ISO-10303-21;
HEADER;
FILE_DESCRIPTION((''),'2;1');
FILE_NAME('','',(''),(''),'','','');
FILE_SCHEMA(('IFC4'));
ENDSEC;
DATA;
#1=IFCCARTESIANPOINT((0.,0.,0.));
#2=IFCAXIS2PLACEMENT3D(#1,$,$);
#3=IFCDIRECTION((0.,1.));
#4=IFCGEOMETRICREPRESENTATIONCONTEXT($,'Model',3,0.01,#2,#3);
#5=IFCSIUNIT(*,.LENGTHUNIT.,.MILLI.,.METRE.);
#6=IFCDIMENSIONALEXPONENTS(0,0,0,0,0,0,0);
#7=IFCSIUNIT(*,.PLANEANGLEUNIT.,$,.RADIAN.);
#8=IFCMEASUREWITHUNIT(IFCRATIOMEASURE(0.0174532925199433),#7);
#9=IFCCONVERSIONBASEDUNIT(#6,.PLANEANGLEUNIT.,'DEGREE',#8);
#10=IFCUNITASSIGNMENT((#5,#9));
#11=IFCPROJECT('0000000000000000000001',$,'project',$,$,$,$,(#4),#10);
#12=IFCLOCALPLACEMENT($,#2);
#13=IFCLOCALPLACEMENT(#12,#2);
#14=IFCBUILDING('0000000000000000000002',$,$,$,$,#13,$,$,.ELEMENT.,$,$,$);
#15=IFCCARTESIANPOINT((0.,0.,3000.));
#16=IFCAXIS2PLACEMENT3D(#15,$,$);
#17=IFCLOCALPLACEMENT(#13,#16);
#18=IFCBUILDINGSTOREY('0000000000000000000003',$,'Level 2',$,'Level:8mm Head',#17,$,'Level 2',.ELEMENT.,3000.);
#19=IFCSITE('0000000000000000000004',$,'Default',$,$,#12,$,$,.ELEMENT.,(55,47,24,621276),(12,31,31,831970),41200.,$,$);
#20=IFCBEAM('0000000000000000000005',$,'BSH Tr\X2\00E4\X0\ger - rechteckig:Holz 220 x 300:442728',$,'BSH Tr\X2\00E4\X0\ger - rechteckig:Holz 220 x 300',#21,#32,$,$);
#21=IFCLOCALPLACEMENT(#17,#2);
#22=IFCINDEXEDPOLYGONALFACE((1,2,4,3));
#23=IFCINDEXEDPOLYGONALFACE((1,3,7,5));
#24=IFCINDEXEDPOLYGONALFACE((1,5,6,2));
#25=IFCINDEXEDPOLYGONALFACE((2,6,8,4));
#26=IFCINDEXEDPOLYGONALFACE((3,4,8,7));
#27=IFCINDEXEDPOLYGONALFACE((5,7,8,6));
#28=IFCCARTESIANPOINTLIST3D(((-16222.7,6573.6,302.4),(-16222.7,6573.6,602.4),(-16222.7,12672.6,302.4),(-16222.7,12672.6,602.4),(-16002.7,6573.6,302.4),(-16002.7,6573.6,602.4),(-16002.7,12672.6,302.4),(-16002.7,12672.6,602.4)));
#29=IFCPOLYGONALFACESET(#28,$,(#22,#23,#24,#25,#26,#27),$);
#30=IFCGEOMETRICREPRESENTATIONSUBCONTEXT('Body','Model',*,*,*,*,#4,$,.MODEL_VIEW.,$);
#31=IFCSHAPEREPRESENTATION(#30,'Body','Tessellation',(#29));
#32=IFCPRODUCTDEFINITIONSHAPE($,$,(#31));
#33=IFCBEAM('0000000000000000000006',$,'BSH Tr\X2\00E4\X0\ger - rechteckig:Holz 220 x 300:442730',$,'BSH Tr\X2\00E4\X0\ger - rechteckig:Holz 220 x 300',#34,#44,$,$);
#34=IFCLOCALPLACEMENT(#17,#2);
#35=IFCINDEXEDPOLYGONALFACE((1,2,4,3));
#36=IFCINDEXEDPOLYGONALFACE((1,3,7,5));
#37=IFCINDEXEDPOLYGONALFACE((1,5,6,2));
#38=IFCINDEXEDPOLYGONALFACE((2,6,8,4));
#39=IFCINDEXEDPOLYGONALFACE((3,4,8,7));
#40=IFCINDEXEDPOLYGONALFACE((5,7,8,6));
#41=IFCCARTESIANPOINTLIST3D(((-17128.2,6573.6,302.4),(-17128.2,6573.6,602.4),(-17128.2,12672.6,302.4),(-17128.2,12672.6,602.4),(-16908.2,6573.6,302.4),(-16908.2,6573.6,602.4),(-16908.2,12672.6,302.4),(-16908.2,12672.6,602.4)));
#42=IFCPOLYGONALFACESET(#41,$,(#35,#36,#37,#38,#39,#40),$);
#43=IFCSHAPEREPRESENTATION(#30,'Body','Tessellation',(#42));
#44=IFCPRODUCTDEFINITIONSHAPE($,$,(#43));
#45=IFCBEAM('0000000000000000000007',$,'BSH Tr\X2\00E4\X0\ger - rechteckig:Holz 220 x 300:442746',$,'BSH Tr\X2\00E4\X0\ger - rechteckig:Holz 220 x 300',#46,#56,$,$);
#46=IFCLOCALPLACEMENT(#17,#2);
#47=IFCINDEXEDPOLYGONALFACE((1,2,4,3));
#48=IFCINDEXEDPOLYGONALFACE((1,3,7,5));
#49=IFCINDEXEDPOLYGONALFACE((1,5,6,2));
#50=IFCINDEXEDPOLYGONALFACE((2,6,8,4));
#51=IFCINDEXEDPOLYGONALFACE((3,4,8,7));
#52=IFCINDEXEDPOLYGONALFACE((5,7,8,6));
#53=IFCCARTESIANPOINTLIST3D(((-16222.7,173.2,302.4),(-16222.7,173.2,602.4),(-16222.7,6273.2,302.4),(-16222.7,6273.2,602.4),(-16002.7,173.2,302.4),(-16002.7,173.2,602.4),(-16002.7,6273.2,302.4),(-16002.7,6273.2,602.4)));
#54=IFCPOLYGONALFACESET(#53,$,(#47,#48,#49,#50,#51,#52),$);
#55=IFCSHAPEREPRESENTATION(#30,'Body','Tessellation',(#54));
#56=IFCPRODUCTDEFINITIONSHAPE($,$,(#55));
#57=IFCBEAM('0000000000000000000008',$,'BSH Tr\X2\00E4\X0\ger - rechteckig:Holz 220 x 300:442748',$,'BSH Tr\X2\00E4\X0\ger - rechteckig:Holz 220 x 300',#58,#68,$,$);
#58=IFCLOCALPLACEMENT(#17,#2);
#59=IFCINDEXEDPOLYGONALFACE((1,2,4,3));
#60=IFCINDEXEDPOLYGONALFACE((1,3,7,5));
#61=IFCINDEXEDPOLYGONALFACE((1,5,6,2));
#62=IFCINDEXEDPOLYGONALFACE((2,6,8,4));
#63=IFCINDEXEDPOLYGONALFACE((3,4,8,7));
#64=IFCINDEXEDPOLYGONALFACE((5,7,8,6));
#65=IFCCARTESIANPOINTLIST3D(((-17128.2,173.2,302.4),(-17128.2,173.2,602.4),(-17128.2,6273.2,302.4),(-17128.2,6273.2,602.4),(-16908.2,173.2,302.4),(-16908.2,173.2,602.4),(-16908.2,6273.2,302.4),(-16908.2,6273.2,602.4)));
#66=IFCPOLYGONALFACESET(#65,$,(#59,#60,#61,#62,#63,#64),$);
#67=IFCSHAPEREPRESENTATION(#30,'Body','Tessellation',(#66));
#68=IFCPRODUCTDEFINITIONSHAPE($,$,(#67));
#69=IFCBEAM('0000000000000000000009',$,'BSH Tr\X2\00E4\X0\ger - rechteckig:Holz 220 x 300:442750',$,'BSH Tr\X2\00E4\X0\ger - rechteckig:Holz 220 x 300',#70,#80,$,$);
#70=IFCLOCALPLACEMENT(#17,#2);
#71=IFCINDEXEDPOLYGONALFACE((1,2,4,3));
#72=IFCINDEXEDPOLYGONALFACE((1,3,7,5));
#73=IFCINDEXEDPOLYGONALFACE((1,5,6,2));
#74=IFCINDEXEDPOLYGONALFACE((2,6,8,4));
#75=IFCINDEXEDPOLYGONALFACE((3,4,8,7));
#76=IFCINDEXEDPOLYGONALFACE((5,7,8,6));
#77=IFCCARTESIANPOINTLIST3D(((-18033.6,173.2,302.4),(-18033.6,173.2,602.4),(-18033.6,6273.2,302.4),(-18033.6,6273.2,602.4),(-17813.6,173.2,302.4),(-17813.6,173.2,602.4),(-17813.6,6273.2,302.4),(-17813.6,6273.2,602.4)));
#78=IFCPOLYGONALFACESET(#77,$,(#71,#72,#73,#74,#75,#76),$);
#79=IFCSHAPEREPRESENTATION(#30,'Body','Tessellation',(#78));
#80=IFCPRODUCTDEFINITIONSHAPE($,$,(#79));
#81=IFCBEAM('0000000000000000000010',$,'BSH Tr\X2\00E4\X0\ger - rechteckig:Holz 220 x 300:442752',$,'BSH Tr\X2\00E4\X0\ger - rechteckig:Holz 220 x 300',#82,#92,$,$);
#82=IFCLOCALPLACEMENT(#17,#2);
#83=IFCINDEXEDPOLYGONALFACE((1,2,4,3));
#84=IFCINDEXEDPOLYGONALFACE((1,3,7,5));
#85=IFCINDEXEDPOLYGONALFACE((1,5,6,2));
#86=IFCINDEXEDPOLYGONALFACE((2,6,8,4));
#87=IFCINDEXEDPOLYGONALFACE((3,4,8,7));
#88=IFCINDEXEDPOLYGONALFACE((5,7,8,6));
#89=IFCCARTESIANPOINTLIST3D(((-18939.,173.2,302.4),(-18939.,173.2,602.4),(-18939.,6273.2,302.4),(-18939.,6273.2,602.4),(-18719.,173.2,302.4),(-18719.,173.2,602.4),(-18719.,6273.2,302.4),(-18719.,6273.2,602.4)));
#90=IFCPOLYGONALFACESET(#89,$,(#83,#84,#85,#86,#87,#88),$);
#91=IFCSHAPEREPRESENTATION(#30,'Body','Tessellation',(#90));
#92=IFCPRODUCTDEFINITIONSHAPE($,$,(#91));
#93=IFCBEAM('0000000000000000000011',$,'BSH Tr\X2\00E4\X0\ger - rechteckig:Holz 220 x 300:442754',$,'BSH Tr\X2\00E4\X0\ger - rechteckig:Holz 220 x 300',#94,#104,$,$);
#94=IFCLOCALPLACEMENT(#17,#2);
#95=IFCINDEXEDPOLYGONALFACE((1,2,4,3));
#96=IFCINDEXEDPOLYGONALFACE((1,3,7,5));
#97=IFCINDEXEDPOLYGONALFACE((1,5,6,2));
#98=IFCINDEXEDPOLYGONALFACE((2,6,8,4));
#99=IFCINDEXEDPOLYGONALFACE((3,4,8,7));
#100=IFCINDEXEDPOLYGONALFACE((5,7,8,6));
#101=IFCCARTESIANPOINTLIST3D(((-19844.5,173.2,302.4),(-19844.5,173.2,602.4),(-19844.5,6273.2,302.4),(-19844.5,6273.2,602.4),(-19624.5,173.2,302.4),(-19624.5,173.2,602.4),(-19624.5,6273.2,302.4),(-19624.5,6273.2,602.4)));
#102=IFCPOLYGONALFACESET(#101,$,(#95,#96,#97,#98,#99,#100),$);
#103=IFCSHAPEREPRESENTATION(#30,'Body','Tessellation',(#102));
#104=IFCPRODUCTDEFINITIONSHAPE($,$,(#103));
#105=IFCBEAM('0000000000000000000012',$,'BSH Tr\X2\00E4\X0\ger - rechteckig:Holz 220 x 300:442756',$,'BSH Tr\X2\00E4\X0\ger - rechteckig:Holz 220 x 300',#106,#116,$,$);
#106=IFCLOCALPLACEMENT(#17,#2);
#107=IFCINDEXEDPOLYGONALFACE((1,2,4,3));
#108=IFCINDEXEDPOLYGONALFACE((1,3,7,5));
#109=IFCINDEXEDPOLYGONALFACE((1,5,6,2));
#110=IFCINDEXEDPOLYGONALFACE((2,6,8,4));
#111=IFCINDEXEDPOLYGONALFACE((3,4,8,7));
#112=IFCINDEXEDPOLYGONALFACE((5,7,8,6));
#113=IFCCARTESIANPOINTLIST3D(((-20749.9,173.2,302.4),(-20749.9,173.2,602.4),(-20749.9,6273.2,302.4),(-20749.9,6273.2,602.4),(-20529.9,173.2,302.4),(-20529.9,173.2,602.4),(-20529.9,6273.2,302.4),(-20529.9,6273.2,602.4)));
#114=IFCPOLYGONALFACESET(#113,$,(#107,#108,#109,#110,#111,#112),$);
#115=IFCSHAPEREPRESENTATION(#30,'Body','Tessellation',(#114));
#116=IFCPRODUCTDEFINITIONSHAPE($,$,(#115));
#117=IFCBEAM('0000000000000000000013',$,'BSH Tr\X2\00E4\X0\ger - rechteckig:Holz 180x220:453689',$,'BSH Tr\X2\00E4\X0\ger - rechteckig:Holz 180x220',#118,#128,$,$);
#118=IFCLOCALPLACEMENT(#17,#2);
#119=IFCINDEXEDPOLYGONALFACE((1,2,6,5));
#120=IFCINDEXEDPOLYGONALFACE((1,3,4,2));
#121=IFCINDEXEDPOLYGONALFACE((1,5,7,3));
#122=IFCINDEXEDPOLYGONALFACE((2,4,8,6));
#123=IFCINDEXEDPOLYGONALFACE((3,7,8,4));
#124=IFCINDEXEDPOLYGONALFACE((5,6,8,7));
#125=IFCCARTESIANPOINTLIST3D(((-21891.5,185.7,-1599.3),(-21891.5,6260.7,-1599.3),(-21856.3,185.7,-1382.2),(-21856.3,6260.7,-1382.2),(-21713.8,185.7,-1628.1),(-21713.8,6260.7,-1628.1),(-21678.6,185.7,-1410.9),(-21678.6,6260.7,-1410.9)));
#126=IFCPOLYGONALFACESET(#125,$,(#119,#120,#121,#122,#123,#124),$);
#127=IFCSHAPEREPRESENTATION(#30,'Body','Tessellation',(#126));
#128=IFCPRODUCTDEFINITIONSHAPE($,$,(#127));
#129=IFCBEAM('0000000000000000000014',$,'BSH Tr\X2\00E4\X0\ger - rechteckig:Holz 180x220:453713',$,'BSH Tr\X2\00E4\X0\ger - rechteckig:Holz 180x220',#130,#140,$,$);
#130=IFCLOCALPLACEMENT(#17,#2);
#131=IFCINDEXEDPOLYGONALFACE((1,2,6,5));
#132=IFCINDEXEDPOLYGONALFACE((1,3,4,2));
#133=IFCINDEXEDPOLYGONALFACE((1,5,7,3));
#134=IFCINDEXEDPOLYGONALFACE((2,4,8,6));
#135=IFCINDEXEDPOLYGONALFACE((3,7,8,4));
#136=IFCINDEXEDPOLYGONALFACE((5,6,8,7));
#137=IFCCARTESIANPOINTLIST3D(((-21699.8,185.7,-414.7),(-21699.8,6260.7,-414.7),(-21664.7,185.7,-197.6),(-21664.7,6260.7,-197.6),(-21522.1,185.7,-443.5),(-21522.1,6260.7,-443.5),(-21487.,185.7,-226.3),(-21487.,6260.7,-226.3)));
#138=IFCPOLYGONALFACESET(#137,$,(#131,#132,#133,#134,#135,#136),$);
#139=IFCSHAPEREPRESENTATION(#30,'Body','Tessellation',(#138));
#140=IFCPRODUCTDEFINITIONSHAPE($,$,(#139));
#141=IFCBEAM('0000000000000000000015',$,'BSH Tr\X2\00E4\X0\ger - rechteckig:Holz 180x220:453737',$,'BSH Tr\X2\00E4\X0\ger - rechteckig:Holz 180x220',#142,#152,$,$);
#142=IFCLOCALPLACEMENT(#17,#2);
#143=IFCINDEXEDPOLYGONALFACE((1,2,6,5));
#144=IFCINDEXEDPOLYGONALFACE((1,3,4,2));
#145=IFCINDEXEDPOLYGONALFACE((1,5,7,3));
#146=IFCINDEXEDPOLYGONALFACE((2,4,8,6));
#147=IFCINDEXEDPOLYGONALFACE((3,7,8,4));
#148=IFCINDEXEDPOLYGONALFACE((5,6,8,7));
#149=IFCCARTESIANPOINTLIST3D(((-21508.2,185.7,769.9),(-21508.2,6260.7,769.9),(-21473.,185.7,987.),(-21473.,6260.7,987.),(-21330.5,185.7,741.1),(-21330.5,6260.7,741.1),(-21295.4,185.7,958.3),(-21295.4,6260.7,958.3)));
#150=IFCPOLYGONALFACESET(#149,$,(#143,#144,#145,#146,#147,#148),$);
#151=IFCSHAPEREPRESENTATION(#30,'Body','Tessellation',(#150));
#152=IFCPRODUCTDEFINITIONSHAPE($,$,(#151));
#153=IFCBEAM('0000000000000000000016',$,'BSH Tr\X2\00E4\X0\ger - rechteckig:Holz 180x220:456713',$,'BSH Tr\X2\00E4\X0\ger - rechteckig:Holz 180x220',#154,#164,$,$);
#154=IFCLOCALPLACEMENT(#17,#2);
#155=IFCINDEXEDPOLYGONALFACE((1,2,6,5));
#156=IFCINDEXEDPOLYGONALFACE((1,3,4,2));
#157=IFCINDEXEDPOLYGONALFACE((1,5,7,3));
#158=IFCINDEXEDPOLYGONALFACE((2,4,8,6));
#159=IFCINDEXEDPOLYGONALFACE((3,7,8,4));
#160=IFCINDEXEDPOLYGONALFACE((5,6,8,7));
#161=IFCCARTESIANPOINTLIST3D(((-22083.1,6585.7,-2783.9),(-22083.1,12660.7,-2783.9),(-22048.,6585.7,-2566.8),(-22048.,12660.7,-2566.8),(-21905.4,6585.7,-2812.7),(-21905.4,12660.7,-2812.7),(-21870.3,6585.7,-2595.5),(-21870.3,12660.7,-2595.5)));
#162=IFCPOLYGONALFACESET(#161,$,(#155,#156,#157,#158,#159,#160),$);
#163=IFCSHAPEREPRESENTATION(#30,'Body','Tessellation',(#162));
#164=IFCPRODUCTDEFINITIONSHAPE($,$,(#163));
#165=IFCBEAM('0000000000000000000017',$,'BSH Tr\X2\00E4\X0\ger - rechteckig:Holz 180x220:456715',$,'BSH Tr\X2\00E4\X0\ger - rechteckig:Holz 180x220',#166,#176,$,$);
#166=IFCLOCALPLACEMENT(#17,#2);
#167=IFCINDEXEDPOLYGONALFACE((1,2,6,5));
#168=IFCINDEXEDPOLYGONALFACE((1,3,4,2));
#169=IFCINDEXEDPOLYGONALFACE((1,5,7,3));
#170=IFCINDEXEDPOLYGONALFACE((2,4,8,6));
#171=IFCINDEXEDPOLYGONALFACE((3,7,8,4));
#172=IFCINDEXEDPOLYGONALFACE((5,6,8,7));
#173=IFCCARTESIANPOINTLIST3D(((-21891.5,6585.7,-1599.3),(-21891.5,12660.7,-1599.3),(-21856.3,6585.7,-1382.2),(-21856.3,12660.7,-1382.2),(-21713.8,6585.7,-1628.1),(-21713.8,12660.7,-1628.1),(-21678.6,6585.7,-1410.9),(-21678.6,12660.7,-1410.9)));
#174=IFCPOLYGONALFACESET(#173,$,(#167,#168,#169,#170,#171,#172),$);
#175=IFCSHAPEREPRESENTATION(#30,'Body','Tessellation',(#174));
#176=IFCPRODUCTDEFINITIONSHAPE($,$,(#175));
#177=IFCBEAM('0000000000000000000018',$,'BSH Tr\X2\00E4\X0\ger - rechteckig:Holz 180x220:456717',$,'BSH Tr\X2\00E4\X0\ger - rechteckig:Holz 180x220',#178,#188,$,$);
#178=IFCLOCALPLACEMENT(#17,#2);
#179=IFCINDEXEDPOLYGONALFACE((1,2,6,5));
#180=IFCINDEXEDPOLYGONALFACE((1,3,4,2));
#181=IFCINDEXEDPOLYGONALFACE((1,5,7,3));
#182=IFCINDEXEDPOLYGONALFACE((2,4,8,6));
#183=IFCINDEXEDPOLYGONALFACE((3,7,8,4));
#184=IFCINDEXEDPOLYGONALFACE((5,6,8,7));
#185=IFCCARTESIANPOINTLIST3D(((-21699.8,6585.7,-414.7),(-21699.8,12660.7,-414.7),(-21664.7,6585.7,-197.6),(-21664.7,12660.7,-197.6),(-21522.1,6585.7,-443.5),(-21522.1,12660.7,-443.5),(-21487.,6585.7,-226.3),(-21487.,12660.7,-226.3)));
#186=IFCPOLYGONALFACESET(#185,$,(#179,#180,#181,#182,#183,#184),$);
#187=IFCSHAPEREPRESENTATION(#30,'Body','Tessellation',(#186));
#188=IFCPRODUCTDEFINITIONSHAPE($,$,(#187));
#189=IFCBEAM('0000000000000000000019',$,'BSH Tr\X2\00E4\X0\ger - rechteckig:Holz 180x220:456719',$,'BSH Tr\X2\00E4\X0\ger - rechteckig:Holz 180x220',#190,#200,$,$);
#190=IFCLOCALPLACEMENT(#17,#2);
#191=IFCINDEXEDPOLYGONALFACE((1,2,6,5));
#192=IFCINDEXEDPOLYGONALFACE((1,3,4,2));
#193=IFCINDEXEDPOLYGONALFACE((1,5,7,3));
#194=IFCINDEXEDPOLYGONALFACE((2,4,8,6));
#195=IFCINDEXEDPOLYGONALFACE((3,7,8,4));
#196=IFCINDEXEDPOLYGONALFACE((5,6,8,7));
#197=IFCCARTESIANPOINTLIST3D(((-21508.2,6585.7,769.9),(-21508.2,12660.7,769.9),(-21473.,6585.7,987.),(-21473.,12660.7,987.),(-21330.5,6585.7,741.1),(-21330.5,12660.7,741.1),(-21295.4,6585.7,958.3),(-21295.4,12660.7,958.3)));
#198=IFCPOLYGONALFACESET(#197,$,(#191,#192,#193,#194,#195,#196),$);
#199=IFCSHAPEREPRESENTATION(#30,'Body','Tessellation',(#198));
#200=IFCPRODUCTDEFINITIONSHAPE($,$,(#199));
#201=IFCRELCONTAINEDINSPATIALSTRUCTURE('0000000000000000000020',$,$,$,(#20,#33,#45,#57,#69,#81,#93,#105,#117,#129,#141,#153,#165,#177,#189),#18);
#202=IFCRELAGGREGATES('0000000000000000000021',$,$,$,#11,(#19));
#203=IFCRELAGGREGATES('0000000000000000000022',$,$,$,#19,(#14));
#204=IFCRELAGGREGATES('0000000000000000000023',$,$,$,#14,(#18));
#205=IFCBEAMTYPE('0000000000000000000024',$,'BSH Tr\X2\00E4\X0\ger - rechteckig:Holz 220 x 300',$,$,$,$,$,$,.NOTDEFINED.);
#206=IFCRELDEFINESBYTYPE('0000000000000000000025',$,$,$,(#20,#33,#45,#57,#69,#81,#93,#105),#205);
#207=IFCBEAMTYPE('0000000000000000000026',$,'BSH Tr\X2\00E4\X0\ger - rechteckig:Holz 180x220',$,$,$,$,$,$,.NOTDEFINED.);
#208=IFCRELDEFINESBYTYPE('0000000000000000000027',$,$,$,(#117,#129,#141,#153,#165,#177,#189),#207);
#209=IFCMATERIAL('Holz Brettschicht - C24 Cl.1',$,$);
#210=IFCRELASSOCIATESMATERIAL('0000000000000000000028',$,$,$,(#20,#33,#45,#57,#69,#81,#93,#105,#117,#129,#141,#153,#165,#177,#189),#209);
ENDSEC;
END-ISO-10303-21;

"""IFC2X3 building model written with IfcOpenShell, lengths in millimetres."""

from ifc_helpers import new_model, entity, si_unit, converted_unit, direction, frame, frame_2d, origin, origin_2d_with_axis, place, context, subcontext, project, spatial, rectangle, extrude, material, type_object, element, save


model = new_model("IFC2X3")

# Units and contexts
model_context = context("Model", 3, precision=0.01, world=origin(), true_north=direction((0.0, 1.0)))
body_context = subcontext(model_context, "Body", "Model", "MODEL_VIEW")
ifc_project = project(units=[si_unit("LENGTHUNIT", "METRE", prefix="MILLI"), converted_unit("PLANEANGLEUNIT", "DEGREE", entity("IfcRatioMeasure", 0.0174532925199433), si_unit("PLANEANGLEUNIT", "RADIAN"), dimensions=[0, 0, 0, 0, 0, 0, 0])], contexts=[model_context])

# Site, building, storey
site_placement = place(None, origin())
site = spatial("IfcSite", under=ifc_project, at=site_placement, Name="Default", CompositionType="ELEMENT", RefLatitude=(55, 47, 24, 621276), RefLongitude=(12, 31, 31, 831970), RefElevation=41200.0)
building_placement = place(site_placement, origin())
building = spatial("IfcBuilding", under=site, at=building_placement, CompositionType="ELEMENT")
storey_placement = place(building_placement, frame((0.0, 0.0, 3000.0)))
storey = spatial("IfcBuildingStorey", under=building, at=storey_placement, Name="Level 2", ObjectType="Level:8mm Head", LongName="Level 2", CompositionType="ELEMENT", Elevation=3000.0)

# Beams
ifc_material = material(Name="Holz Brettschicht - C24 Cl.1")
beam_type_1 = type_object("IfcBeamType", Name="BSH Träger - rechteckig:Holz 220 x 300", PredefinedType="NOTDEFINED")
beam_1_placement = place(storey_placement, frame((-16112.7, 12736.0, 602.4), z_axis=(0.0, 0.0, 1.0), x_axis=(0.0, -1.0, 0.0)))
element("IfcBeam", 1, at=beam_1_placement, inside=storey, type_object=beam_type_1, material=ifc_material, Name="BSH Träger - rechteckig:Holz 220 x 300:442728", ObjectType="BSH Träger - rechteckig:Holz 220 x 300", context=body_context, shape_type="SweptSolid", body=[
    extrude(rectangle(XDim=300.0, YDim=220.0, at=frame_2d((0.0, 0.0), x_axis=(1.0, 0.0))), frame((63.4, 0.0, -150.0), z_axis=(1.0, 0.0, 0.0), x_axis=(0.0, 0.0, -1.0)), (0.0, 0.0, 1.0), 6099.0),
])
beam_2_placement = place(storey_placement, frame((-17018.2, 12736.0, 602.4), z_axis=(0.0, 0.0, 1.0), x_axis=(0.0, -1.0, 0.0)))
element("IfcBeam", 2, at=beam_2_placement, inside=storey, type_object=beam_type_1, material=ifc_material, Name="BSH Träger - rechteckig:Holz 220 x 300:442730", ObjectType="BSH Träger - rechteckig:Holz 220 x 300", context=body_context, shape_type="SweptSolid", body=[
    extrude(rectangle(XDim=300.0, YDim=220.0, at=frame_2d((0.0, 0.0), x_axis=(1.0, 0.0))), frame((63.4, 0.0, -150.0), z_axis=(1.0, 0.0, 0.0), x_axis=(0.0, 0.0, -1.0)), (0.0, 0.0, 1.0), 6099.0),
])
beam_3_placement = place(storey_placement, frame((-16112.7, 6423.2, 602.4), z_axis=(0.0, 0.0, 1.0), x_axis=(0.0, -1.0, 0.0)))
element("IfcBeam", 3, at=beam_3_placement, inside=storey, type_object=beam_type_1, material=ifc_material, Name="BSH Träger - rechteckig:Holz 220 x 300:442746", ObjectType="BSH Träger - rechteckig:Holz 220 x 300", context=body_context, shape_type="SweptSolid", body=[
    extrude(rectangle(XDim=300.0, YDim=220.0, at=frame_2d((0.0, 0.0), x_axis=(1.0, 0.0))), frame((150.0, 0.0, -150.0), z_axis=(1.0, 0.0, 0.0), x_axis=(0.0, 0.0, -1.0)), (0.0, 0.0, 1.0), 6100.0),
])
for number, where, z_axis, x_axis, name in (
    (4, (-17018.2, 6423.2, 602.4), (0.0, 0.0, 1.0), (0.0, -1.0, 0.0), "BSH Träger - rechteckig:Holz 220 x 300:442748"),
    (5, (-17923.6, 6423.2, 602.4), (0.0, 0.0, 1.0), (0.0, -1.0, 0.0), "BSH Träger - rechteckig:Holz 220 x 300:442750"),
    (6, (-18829.0, 6423.2, 602.4), (0.0, 0.0, 1.0), (0.0, -1.0, 0.0), "BSH Träger - rechteckig:Holz 220 x 300:442752"),
):
    element("IfcBeam", number, at=place(storey_placement, frame(where, z_axis=z_axis, x_axis=x_axis)), inside=storey, type_object=beam_type_1, material=ifc_material, Name=name, ObjectType="BSH Träger - rechteckig:Holz 220 x 300", context=body_context, shape_type="SweptSolid", body=[
        extrude(rectangle(XDim=300.0, YDim=220.0, at=frame_2d((0.0, 0.0), x_axis=(1.0, 0.0))), frame((150.0, 0.0, -150.0), z_axis=(1.0, 0.0, 0.0), x_axis=(0.0, 0.0, -1.0)), (0.0, 0.0, 1.0), 6100.0),
    ])
for number, where, z_axis, x_axis, name in (
    (7, (-19734.5, 6423.2, 602.4), (0.0, 0.0, 1.0), (0.0, -1.0, 0.0), "BSH Träger - rechteckig:Holz 220 x 300:442754"),
    (8, (-20639.9, 6423.2, 602.4), (0.0, 0.0, 1.0), (0.0, -1.0, 0.0), "BSH Träger - rechteckig:Holz 220 x 300:442756"),
):
    element("IfcBeam", number, at=place(storey_placement, frame(where, z_axis=z_axis, x_axis=x_axis)), inside=storey, type_object=beam_type_1, material=ifc_material, Name=name, ObjectType="BSH Träger - rechteckig:Holz 220 x 300", context=body_context, shape_type="SweptSolid", body=[
        extrude(rectangle(XDim=300.0, YDim=220.0, at=origin_2d_with_axis()), frame((150.0, 0.0, -150.0), z_axis=(1.0, 0.0, 0.0), x_axis=(0.0, 0.0, -1.0)), (0.0, 0.0, 1.0), 6100.0),
    ])
beam_type_2 = type_object("IfcBeamType", Name="BSH Träger - rechteckig:Holz 180x220", PredefinedType="NOTDEFINED")
beam_4_placement = place(storey_placement, frame((-21856.3, 5823.2, -1382.2), z_axis=(0.0, 0.0, 1.0), x_axis=(0.0, -1.0, 0.0)))
element("IfcBeam", 9, at=beam_4_placement, inside=storey, type_object=beam_type_2, material=ifc_material, Name="BSH Träger - rechteckig:Holz 180x220:453689", ObjectType="BSH Träger - rechteckig:Holz 180x220", context=body_context, shape_type="SweptSolid", body=[
    extrude(rectangle(XDim=220.0, YDim=180.0, at=frame_2d((0.0, 0.0), x_axis=(1.0, 0.0))), frame((-437.5, 71.3, -123.0), z_axis=(1.0, 0.0, 0.0), x_axis=(0.0, 0.159701, 0.987165)), (0.0, 0.0, 1.0), 6075.0),
])
beam_5_placement = place(storey_placement, frame((-21664.7, 5823.2, -197.6), z_axis=(0.0, 0.0, 1.0), x_axis=(0.0, -1.0, 0.0)))
element("IfcBeam", 10, at=beam_5_placement, inside=storey, type_object=beam_type_2, material=ifc_material, Name="BSH Träger - rechteckig:Holz 180x220:453713", ObjectType="BSH Träger - rechteckig:Holz 180x220", context=body_context, shape_type="SweptSolid", body=[
    extrude(rectangle(XDim=220.0, YDim=180.0, at=frame_2d((0.0, 0.0), x_axis=(1.0, 0.0))), frame((-437.5, 71.3, -123.0), z_axis=(1.0, 0.0, 0.0), x_axis=(0.0, 0.159701, 0.987165)), (0.0, 0.0, 1.0), 6075.0),
])
beam_6_placement = place(storey_placement, frame((-21473.0, 5823.2, 987.0), z_axis=(0.0, 0.0, 1.0), x_axis=(0.0, -1.0, 0.0)))
element("IfcBeam", 11, at=beam_6_placement, inside=storey, type_object=beam_type_2, material=ifc_material, Name="BSH Träger - rechteckig:Holz 180x220:453737", ObjectType="BSH Träger - rechteckig:Holz 180x220", context=body_context, shape_type="SweptSolid", body=[
    extrude(rectangle(XDim=220.0, YDim=180.0, at=frame_2d((0.0, 0.0), x_axis=(1.0, 0.0))), frame((-437.5, 71.3, -123.0), z_axis=(1.0, 0.0, 0.0), x_axis=(0.0, 0.159701, 0.987165)), (0.0, 0.0, 1.0), 6075.0),
])
beam_7_placement = place(storey_placement, frame((-22048.0, 12223.2, -2566.8), z_axis=(0.0, 0.0, 1.0), x_axis=(0.0, -1.0, 0.0)))
element("IfcBeam", 12, at=beam_7_placement, inside=storey, type_object=beam_type_2, material=ifc_material, Name="BSH Träger - rechteckig:Holz 180x220:456713", ObjectType="BSH Träger - rechteckig:Holz 180x220", context=body_context, shape_type="SweptSolid", body=[
    extrude(rectangle(XDim=220.0, YDim=180.0, at=frame_2d((0.0, 0.0), x_axis=(1.0, 0.0))), frame((-437.5, 71.3, -123.0), z_axis=(1.0, 0.0, 0.0), x_axis=(0.0, 0.159701, 0.987165)), (0.0, 0.0, 1.0), 6075.0),
])
beam_8_placement = place(storey_placement, frame((-21856.3, 12223.2, -1382.2), z_axis=(0.0, 0.0, 1.0), x_axis=(0.0, -1.0, 0.0)))
element("IfcBeam", 13, at=beam_8_placement, inside=storey, type_object=beam_type_2, material=ifc_material, Name="BSH Träger - rechteckig:Holz 180x220:456715", ObjectType="BSH Träger - rechteckig:Holz 180x220", context=body_context, shape_type="SweptSolid", body=[
    extrude(rectangle(XDim=220.0, YDim=180.0, at=frame_2d((0.0, 0.0), x_axis=(1.0, 0.0))), frame((-437.5, 71.3, -123.0), z_axis=(1.0, 0.0, 0.0), x_axis=(0.0, 0.159701, 0.987165)), (0.0, 0.0, 1.0), 6075.0),
])
beam_9_placement = place(storey_placement, frame((-21664.7, 12223.2, -197.6), z_axis=(0.0, 0.0, 1.0), x_axis=(0.0, -1.0, 0.0)))
element("IfcBeam", 14, at=beam_9_placement, inside=storey, type_object=beam_type_2, material=ifc_material, Name="BSH Träger - rechteckig:Holz 180x220:456717", ObjectType="BSH Träger - rechteckig:Holz 180x220", context=body_context, shape_type="SweptSolid", body=[
    extrude(rectangle(XDim=220.0, YDim=180.0, at=frame_2d((0.0, 0.0), x_axis=(1.0, 0.0))), frame((-437.5, 71.3, -123.0), z_axis=(1.0, 0.0, 0.0), x_axis=(0.0, 0.159701, 0.987165)), (0.0, 0.0, 1.0), 6075.0),
])
beam_10_placement = place(storey_placement, frame((-21473.0, 12223.2, 987.0), z_axis=(0.0, 0.0, 1.0), x_axis=(0.0, -1.0, 0.0)))
element("IfcBeam", 15, at=beam_10_placement, inside=storey, type_object=beam_type_2, material=ifc_material, Name="BSH Träger - rechteckig:Holz 180x220:456719", ObjectType="BSH Träger - rechteckig:Holz 180x220", context=body_context, shape_type="SweptSolid", body=[
    extrude(rectangle(XDim=220.0, YDim=180.0, at=frame_2d((0.0, 0.0), x_axis=(1.0, 0.0))), frame((-437.5, 71.3, -123.0), z_axis=(1.0, 0.0, 0.0), x_axis=(0.0, 0.159701, 0.987165)), (0.0, 0.0, 1.0), 6075.0),
])

save(model, "model.ifc")
